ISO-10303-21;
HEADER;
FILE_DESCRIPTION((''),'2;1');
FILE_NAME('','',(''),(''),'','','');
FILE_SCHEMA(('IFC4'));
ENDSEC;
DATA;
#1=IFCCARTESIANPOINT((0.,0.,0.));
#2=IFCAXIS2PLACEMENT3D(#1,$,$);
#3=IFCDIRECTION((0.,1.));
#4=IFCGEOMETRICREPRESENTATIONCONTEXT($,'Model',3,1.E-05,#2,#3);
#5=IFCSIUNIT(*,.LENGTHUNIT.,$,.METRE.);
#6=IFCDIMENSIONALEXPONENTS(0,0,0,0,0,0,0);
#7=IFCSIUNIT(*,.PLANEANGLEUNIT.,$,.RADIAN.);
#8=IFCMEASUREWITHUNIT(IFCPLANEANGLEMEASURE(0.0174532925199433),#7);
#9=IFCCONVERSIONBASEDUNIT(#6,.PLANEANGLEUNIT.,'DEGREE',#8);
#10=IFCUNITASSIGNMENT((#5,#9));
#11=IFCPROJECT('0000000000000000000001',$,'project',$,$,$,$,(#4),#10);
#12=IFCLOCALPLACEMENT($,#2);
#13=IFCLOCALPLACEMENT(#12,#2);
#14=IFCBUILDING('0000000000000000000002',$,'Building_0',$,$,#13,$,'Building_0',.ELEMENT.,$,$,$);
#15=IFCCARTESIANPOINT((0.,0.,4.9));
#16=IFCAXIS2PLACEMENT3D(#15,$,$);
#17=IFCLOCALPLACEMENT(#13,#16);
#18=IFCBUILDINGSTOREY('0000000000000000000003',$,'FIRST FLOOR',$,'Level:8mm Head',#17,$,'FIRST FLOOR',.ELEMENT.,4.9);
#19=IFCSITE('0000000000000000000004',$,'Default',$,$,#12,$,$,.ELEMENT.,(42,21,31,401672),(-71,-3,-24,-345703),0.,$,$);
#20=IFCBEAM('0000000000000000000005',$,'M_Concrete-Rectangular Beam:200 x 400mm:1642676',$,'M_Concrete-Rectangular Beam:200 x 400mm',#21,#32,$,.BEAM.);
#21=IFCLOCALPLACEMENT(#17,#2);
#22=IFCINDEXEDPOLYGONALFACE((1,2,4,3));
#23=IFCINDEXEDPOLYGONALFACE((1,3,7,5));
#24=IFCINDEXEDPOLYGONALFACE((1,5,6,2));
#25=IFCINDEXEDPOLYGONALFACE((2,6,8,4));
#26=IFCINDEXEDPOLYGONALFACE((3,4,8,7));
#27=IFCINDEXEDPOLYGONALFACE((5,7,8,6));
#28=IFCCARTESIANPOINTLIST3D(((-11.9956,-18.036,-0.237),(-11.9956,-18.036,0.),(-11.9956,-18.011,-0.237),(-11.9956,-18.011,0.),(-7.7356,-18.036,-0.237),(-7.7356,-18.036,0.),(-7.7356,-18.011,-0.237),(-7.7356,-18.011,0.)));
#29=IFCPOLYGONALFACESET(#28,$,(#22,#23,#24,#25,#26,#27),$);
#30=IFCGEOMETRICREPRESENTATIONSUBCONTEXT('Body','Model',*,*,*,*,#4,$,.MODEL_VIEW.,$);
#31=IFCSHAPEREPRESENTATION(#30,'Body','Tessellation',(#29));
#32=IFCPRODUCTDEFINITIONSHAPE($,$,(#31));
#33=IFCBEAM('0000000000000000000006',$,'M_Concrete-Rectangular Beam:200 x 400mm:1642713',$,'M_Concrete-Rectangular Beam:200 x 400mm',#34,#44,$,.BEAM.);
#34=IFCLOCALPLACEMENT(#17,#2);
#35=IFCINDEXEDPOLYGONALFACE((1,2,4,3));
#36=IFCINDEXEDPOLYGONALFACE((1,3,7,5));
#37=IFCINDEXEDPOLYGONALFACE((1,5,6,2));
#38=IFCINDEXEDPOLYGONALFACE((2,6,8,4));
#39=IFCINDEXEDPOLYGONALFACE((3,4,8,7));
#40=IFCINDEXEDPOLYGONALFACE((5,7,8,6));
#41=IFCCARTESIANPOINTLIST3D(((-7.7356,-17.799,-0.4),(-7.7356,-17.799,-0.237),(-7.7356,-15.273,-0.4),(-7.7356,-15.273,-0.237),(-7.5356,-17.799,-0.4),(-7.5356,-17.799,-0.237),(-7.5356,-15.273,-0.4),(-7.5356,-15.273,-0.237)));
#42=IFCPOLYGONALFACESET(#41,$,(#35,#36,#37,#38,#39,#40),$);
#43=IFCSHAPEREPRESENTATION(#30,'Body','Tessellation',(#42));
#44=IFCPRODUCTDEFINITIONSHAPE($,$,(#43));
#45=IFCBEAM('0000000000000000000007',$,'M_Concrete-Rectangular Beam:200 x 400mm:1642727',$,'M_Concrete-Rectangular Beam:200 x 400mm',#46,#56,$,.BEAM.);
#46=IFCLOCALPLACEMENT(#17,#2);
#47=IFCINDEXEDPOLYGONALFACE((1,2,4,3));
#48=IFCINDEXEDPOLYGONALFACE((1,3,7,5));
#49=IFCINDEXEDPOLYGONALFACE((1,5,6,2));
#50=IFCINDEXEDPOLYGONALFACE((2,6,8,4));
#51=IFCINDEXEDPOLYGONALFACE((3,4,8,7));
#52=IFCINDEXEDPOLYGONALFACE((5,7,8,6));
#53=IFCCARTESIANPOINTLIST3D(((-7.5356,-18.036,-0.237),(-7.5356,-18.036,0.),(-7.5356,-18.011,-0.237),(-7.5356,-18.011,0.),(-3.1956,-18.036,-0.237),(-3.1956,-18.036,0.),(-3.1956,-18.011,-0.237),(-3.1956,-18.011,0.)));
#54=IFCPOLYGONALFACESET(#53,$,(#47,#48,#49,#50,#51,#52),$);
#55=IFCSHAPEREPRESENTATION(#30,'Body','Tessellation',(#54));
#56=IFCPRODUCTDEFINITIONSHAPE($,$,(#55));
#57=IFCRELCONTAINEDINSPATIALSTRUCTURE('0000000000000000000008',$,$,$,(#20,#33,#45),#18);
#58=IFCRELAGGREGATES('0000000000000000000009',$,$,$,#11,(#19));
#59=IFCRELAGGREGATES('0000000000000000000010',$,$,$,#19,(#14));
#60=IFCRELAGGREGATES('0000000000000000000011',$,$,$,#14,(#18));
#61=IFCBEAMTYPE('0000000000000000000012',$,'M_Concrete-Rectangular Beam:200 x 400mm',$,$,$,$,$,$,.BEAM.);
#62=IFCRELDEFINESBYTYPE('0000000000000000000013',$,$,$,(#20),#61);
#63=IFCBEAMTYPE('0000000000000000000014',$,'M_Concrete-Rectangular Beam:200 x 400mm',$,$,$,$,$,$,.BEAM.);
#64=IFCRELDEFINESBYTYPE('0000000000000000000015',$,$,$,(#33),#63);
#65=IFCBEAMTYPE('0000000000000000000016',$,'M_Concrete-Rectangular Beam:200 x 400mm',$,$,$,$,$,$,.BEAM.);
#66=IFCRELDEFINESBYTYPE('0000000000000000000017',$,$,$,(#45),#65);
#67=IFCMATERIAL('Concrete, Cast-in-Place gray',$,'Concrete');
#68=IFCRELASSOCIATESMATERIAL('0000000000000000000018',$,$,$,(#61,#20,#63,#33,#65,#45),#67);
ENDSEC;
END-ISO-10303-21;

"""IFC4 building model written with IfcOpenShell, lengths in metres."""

from ifc_helpers import new_model, entity, si_unit, converted_unit, direction, frame, origin, place, context, subcontext, project, spatial, indexed_curve, outline, extrude, source, transform, mapped, material, type_object, type_shapes, element, save


model = new_model("IFC4")

# Units and contexts
model_context = context("Model", 3, precision=1e-05, world=origin(), true_north=direction((0.0, 1.0)))
body_context = subcontext(model_context, "Body", "Model", "MODEL_VIEW")
ifc_project = project(units=[si_unit("LENGTHUNIT", "METRE"), converted_unit("PLANEANGLEUNIT", "DEGREE", entity("IfcPlaneAngleMeasure", 0.0174532925199433), si_unit("PLANEANGLEUNIT", "RADIAN"), dimensions=[0, 0, 0, 0, 0, 0, 0])], contexts=[model_context])

# Site, building, storey
site_placement = place(None, origin())
site = spatial("IfcSite", under=ifc_project, at=site_placement, Name="Default", CompositionType="ELEMENT", RefLatitude=(42, 21, 31, 401672), RefLongitude=(-71, -3, -24, -345703), RefElevation=0.0)
building_placement = place(site_placement, origin())
building = spatial("IfcBuilding", under=site, at=building_placement, Name="Building_0", LongName="Building_0", CompositionType="ELEMENT")
storey_placement = place(building_placement, frame((0.0, 0.0, 4.9)))
storey = spatial("IfcBuildingStorey", under=building, at=storey_placement, Name="FIRST FLOOR", ObjectType="Level:8mm Head", LongName="FIRST FLOOR", CompositionType="ELEMENT", Elevation=4.9)

# Beams
ifc_material = material(Name="Concrete, Cast-in-Place gray", Category="Concrete")
beam_type_1 = type_object("IfcBeamType", Name="M_Concrete-Rectangular Beam:200 x 400mm", PredefinedType="BEAM", material=ifc_material)
shared_shape_1 = source(origin(), body_context, "Body", "SweptSolid", [
    extrude(outline(indexed_curve([(-0.1185, -0.0125), (0.1185, -0.0125), (0.1185, 0.0125), (-0.1185, 0.0125), (-0.1185, -0.0125)], self_intersect=False)), frame((-11.9956, -18.0235, 4.7815), z_axis=(1.0, 0.0, 0.0), x_axis=(0.0, 0.0, -1.0)), (0.0, 0.0, 1.0), 4.26),
])
type_shapes(beam_type_1, [shared_shape_1])
beam_1_placement = place(storey_placement, frame((0.0, 0.0, -4.9)))
element("IfcBeam", 1, at=beam_1_placement, inside=storey, type_object=beam_type_1, material=ifc_material, Name="M_Concrete-Rectangular Beam:200 x 400mm:1642676", ObjectType="M_Concrete-Rectangular Beam:200 x 400mm", PredefinedType="BEAM", context=body_context, shape_type="MappedRepresentation", body=[
    mapped(shared_shape_1, transform((0.0, 0.0, 0.0), scale=1.0)),
])
beam_type_2 = type_object("IfcBeamType", Name="M_Concrete-Rectangular Beam:200 x 400mm", PredefinedType="BEAM", material=ifc_material)
shared_shape_2 = source(origin(), body_context, "Body", "SweptSolid", [
    extrude(outline(indexed_curve([(-0.1, -0.0815), (0.1, -0.0815), (0.1, 0.0815), (-0.1, 0.0815), (-0.1, -0.0815)], self_intersect=False)), frame((-7.6356, -15.273, 4.5815), z_axis=(0.0, -1.0, 0.0), x_axis=(-1.0, 0.0, 0.0)), (0.0, 0.0, 1.0), 2.526),
])
type_shapes(beam_type_2, [shared_shape_2])
beam_2_placement = place(storey_placement, frame((0.0, 0.0, -4.9)))
element("IfcBeam", 2, at=beam_2_placement, inside=storey, type_object=beam_type_2, material=ifc_material, Name="M_Concrete-Rectangular Beam:200 x 400mm:1642713", ObjectType="M_Concrete-Rectangular Beam:200 x 400mm", PredefinedType="BEAM", context=body_context, shape_type="MappedRepresentation", body=[
    mapped(shared_shape_2, transform((0.0, 0.0, 0.0), scale=1.0)),
])
beam_type_3 = type_object("IfcBeamType", Name="M_Concrete-Rectangular Beam:200 x 400mm", PredefinedType="BEAM", material=ifc_material)
shared_shape_3 = source(origin(), body_context, "Body", "SweptSolid", [
    extrude(outline(indexed_curve([(-0.1185, -0.0125), (0.1185, -0.0125), (0.1185, 0.0125), (-0.1185, 0.0125), (-0.1185, -0.0125)], self_intersect=False)), frame((-7.5356, -18.0235, 4.7815), z_axis=(1.0, 0.0, 0.0), x_axis=(0.0, 0.0, -1.0)), (0.0, 0.0, 1.0), 4.34),
])
type_shapes(beam_type_3, [shared_shape_3])
beam_3_placement = place(storey_placement, frame((0.0, 0.0, -4.9)))
element("IfcBeam", 3, at=beam_3_placement, inside=storey, type_object=beam_type_3, material=ifc_material, Name="M_Concrete-Rectangular Beam:200 x 400mm:1642727", ObjectType="M_Concrete-Rectangular Beam:200 x 400mm", PredefinedType="BEAM", context=body_context, shape_type="MappedRepresentation", body=[
    mapped(shared_shape_3, transform((0.0, 0.0, 0.0), scale=1.0)),
])

save(model, "model.ifc")
